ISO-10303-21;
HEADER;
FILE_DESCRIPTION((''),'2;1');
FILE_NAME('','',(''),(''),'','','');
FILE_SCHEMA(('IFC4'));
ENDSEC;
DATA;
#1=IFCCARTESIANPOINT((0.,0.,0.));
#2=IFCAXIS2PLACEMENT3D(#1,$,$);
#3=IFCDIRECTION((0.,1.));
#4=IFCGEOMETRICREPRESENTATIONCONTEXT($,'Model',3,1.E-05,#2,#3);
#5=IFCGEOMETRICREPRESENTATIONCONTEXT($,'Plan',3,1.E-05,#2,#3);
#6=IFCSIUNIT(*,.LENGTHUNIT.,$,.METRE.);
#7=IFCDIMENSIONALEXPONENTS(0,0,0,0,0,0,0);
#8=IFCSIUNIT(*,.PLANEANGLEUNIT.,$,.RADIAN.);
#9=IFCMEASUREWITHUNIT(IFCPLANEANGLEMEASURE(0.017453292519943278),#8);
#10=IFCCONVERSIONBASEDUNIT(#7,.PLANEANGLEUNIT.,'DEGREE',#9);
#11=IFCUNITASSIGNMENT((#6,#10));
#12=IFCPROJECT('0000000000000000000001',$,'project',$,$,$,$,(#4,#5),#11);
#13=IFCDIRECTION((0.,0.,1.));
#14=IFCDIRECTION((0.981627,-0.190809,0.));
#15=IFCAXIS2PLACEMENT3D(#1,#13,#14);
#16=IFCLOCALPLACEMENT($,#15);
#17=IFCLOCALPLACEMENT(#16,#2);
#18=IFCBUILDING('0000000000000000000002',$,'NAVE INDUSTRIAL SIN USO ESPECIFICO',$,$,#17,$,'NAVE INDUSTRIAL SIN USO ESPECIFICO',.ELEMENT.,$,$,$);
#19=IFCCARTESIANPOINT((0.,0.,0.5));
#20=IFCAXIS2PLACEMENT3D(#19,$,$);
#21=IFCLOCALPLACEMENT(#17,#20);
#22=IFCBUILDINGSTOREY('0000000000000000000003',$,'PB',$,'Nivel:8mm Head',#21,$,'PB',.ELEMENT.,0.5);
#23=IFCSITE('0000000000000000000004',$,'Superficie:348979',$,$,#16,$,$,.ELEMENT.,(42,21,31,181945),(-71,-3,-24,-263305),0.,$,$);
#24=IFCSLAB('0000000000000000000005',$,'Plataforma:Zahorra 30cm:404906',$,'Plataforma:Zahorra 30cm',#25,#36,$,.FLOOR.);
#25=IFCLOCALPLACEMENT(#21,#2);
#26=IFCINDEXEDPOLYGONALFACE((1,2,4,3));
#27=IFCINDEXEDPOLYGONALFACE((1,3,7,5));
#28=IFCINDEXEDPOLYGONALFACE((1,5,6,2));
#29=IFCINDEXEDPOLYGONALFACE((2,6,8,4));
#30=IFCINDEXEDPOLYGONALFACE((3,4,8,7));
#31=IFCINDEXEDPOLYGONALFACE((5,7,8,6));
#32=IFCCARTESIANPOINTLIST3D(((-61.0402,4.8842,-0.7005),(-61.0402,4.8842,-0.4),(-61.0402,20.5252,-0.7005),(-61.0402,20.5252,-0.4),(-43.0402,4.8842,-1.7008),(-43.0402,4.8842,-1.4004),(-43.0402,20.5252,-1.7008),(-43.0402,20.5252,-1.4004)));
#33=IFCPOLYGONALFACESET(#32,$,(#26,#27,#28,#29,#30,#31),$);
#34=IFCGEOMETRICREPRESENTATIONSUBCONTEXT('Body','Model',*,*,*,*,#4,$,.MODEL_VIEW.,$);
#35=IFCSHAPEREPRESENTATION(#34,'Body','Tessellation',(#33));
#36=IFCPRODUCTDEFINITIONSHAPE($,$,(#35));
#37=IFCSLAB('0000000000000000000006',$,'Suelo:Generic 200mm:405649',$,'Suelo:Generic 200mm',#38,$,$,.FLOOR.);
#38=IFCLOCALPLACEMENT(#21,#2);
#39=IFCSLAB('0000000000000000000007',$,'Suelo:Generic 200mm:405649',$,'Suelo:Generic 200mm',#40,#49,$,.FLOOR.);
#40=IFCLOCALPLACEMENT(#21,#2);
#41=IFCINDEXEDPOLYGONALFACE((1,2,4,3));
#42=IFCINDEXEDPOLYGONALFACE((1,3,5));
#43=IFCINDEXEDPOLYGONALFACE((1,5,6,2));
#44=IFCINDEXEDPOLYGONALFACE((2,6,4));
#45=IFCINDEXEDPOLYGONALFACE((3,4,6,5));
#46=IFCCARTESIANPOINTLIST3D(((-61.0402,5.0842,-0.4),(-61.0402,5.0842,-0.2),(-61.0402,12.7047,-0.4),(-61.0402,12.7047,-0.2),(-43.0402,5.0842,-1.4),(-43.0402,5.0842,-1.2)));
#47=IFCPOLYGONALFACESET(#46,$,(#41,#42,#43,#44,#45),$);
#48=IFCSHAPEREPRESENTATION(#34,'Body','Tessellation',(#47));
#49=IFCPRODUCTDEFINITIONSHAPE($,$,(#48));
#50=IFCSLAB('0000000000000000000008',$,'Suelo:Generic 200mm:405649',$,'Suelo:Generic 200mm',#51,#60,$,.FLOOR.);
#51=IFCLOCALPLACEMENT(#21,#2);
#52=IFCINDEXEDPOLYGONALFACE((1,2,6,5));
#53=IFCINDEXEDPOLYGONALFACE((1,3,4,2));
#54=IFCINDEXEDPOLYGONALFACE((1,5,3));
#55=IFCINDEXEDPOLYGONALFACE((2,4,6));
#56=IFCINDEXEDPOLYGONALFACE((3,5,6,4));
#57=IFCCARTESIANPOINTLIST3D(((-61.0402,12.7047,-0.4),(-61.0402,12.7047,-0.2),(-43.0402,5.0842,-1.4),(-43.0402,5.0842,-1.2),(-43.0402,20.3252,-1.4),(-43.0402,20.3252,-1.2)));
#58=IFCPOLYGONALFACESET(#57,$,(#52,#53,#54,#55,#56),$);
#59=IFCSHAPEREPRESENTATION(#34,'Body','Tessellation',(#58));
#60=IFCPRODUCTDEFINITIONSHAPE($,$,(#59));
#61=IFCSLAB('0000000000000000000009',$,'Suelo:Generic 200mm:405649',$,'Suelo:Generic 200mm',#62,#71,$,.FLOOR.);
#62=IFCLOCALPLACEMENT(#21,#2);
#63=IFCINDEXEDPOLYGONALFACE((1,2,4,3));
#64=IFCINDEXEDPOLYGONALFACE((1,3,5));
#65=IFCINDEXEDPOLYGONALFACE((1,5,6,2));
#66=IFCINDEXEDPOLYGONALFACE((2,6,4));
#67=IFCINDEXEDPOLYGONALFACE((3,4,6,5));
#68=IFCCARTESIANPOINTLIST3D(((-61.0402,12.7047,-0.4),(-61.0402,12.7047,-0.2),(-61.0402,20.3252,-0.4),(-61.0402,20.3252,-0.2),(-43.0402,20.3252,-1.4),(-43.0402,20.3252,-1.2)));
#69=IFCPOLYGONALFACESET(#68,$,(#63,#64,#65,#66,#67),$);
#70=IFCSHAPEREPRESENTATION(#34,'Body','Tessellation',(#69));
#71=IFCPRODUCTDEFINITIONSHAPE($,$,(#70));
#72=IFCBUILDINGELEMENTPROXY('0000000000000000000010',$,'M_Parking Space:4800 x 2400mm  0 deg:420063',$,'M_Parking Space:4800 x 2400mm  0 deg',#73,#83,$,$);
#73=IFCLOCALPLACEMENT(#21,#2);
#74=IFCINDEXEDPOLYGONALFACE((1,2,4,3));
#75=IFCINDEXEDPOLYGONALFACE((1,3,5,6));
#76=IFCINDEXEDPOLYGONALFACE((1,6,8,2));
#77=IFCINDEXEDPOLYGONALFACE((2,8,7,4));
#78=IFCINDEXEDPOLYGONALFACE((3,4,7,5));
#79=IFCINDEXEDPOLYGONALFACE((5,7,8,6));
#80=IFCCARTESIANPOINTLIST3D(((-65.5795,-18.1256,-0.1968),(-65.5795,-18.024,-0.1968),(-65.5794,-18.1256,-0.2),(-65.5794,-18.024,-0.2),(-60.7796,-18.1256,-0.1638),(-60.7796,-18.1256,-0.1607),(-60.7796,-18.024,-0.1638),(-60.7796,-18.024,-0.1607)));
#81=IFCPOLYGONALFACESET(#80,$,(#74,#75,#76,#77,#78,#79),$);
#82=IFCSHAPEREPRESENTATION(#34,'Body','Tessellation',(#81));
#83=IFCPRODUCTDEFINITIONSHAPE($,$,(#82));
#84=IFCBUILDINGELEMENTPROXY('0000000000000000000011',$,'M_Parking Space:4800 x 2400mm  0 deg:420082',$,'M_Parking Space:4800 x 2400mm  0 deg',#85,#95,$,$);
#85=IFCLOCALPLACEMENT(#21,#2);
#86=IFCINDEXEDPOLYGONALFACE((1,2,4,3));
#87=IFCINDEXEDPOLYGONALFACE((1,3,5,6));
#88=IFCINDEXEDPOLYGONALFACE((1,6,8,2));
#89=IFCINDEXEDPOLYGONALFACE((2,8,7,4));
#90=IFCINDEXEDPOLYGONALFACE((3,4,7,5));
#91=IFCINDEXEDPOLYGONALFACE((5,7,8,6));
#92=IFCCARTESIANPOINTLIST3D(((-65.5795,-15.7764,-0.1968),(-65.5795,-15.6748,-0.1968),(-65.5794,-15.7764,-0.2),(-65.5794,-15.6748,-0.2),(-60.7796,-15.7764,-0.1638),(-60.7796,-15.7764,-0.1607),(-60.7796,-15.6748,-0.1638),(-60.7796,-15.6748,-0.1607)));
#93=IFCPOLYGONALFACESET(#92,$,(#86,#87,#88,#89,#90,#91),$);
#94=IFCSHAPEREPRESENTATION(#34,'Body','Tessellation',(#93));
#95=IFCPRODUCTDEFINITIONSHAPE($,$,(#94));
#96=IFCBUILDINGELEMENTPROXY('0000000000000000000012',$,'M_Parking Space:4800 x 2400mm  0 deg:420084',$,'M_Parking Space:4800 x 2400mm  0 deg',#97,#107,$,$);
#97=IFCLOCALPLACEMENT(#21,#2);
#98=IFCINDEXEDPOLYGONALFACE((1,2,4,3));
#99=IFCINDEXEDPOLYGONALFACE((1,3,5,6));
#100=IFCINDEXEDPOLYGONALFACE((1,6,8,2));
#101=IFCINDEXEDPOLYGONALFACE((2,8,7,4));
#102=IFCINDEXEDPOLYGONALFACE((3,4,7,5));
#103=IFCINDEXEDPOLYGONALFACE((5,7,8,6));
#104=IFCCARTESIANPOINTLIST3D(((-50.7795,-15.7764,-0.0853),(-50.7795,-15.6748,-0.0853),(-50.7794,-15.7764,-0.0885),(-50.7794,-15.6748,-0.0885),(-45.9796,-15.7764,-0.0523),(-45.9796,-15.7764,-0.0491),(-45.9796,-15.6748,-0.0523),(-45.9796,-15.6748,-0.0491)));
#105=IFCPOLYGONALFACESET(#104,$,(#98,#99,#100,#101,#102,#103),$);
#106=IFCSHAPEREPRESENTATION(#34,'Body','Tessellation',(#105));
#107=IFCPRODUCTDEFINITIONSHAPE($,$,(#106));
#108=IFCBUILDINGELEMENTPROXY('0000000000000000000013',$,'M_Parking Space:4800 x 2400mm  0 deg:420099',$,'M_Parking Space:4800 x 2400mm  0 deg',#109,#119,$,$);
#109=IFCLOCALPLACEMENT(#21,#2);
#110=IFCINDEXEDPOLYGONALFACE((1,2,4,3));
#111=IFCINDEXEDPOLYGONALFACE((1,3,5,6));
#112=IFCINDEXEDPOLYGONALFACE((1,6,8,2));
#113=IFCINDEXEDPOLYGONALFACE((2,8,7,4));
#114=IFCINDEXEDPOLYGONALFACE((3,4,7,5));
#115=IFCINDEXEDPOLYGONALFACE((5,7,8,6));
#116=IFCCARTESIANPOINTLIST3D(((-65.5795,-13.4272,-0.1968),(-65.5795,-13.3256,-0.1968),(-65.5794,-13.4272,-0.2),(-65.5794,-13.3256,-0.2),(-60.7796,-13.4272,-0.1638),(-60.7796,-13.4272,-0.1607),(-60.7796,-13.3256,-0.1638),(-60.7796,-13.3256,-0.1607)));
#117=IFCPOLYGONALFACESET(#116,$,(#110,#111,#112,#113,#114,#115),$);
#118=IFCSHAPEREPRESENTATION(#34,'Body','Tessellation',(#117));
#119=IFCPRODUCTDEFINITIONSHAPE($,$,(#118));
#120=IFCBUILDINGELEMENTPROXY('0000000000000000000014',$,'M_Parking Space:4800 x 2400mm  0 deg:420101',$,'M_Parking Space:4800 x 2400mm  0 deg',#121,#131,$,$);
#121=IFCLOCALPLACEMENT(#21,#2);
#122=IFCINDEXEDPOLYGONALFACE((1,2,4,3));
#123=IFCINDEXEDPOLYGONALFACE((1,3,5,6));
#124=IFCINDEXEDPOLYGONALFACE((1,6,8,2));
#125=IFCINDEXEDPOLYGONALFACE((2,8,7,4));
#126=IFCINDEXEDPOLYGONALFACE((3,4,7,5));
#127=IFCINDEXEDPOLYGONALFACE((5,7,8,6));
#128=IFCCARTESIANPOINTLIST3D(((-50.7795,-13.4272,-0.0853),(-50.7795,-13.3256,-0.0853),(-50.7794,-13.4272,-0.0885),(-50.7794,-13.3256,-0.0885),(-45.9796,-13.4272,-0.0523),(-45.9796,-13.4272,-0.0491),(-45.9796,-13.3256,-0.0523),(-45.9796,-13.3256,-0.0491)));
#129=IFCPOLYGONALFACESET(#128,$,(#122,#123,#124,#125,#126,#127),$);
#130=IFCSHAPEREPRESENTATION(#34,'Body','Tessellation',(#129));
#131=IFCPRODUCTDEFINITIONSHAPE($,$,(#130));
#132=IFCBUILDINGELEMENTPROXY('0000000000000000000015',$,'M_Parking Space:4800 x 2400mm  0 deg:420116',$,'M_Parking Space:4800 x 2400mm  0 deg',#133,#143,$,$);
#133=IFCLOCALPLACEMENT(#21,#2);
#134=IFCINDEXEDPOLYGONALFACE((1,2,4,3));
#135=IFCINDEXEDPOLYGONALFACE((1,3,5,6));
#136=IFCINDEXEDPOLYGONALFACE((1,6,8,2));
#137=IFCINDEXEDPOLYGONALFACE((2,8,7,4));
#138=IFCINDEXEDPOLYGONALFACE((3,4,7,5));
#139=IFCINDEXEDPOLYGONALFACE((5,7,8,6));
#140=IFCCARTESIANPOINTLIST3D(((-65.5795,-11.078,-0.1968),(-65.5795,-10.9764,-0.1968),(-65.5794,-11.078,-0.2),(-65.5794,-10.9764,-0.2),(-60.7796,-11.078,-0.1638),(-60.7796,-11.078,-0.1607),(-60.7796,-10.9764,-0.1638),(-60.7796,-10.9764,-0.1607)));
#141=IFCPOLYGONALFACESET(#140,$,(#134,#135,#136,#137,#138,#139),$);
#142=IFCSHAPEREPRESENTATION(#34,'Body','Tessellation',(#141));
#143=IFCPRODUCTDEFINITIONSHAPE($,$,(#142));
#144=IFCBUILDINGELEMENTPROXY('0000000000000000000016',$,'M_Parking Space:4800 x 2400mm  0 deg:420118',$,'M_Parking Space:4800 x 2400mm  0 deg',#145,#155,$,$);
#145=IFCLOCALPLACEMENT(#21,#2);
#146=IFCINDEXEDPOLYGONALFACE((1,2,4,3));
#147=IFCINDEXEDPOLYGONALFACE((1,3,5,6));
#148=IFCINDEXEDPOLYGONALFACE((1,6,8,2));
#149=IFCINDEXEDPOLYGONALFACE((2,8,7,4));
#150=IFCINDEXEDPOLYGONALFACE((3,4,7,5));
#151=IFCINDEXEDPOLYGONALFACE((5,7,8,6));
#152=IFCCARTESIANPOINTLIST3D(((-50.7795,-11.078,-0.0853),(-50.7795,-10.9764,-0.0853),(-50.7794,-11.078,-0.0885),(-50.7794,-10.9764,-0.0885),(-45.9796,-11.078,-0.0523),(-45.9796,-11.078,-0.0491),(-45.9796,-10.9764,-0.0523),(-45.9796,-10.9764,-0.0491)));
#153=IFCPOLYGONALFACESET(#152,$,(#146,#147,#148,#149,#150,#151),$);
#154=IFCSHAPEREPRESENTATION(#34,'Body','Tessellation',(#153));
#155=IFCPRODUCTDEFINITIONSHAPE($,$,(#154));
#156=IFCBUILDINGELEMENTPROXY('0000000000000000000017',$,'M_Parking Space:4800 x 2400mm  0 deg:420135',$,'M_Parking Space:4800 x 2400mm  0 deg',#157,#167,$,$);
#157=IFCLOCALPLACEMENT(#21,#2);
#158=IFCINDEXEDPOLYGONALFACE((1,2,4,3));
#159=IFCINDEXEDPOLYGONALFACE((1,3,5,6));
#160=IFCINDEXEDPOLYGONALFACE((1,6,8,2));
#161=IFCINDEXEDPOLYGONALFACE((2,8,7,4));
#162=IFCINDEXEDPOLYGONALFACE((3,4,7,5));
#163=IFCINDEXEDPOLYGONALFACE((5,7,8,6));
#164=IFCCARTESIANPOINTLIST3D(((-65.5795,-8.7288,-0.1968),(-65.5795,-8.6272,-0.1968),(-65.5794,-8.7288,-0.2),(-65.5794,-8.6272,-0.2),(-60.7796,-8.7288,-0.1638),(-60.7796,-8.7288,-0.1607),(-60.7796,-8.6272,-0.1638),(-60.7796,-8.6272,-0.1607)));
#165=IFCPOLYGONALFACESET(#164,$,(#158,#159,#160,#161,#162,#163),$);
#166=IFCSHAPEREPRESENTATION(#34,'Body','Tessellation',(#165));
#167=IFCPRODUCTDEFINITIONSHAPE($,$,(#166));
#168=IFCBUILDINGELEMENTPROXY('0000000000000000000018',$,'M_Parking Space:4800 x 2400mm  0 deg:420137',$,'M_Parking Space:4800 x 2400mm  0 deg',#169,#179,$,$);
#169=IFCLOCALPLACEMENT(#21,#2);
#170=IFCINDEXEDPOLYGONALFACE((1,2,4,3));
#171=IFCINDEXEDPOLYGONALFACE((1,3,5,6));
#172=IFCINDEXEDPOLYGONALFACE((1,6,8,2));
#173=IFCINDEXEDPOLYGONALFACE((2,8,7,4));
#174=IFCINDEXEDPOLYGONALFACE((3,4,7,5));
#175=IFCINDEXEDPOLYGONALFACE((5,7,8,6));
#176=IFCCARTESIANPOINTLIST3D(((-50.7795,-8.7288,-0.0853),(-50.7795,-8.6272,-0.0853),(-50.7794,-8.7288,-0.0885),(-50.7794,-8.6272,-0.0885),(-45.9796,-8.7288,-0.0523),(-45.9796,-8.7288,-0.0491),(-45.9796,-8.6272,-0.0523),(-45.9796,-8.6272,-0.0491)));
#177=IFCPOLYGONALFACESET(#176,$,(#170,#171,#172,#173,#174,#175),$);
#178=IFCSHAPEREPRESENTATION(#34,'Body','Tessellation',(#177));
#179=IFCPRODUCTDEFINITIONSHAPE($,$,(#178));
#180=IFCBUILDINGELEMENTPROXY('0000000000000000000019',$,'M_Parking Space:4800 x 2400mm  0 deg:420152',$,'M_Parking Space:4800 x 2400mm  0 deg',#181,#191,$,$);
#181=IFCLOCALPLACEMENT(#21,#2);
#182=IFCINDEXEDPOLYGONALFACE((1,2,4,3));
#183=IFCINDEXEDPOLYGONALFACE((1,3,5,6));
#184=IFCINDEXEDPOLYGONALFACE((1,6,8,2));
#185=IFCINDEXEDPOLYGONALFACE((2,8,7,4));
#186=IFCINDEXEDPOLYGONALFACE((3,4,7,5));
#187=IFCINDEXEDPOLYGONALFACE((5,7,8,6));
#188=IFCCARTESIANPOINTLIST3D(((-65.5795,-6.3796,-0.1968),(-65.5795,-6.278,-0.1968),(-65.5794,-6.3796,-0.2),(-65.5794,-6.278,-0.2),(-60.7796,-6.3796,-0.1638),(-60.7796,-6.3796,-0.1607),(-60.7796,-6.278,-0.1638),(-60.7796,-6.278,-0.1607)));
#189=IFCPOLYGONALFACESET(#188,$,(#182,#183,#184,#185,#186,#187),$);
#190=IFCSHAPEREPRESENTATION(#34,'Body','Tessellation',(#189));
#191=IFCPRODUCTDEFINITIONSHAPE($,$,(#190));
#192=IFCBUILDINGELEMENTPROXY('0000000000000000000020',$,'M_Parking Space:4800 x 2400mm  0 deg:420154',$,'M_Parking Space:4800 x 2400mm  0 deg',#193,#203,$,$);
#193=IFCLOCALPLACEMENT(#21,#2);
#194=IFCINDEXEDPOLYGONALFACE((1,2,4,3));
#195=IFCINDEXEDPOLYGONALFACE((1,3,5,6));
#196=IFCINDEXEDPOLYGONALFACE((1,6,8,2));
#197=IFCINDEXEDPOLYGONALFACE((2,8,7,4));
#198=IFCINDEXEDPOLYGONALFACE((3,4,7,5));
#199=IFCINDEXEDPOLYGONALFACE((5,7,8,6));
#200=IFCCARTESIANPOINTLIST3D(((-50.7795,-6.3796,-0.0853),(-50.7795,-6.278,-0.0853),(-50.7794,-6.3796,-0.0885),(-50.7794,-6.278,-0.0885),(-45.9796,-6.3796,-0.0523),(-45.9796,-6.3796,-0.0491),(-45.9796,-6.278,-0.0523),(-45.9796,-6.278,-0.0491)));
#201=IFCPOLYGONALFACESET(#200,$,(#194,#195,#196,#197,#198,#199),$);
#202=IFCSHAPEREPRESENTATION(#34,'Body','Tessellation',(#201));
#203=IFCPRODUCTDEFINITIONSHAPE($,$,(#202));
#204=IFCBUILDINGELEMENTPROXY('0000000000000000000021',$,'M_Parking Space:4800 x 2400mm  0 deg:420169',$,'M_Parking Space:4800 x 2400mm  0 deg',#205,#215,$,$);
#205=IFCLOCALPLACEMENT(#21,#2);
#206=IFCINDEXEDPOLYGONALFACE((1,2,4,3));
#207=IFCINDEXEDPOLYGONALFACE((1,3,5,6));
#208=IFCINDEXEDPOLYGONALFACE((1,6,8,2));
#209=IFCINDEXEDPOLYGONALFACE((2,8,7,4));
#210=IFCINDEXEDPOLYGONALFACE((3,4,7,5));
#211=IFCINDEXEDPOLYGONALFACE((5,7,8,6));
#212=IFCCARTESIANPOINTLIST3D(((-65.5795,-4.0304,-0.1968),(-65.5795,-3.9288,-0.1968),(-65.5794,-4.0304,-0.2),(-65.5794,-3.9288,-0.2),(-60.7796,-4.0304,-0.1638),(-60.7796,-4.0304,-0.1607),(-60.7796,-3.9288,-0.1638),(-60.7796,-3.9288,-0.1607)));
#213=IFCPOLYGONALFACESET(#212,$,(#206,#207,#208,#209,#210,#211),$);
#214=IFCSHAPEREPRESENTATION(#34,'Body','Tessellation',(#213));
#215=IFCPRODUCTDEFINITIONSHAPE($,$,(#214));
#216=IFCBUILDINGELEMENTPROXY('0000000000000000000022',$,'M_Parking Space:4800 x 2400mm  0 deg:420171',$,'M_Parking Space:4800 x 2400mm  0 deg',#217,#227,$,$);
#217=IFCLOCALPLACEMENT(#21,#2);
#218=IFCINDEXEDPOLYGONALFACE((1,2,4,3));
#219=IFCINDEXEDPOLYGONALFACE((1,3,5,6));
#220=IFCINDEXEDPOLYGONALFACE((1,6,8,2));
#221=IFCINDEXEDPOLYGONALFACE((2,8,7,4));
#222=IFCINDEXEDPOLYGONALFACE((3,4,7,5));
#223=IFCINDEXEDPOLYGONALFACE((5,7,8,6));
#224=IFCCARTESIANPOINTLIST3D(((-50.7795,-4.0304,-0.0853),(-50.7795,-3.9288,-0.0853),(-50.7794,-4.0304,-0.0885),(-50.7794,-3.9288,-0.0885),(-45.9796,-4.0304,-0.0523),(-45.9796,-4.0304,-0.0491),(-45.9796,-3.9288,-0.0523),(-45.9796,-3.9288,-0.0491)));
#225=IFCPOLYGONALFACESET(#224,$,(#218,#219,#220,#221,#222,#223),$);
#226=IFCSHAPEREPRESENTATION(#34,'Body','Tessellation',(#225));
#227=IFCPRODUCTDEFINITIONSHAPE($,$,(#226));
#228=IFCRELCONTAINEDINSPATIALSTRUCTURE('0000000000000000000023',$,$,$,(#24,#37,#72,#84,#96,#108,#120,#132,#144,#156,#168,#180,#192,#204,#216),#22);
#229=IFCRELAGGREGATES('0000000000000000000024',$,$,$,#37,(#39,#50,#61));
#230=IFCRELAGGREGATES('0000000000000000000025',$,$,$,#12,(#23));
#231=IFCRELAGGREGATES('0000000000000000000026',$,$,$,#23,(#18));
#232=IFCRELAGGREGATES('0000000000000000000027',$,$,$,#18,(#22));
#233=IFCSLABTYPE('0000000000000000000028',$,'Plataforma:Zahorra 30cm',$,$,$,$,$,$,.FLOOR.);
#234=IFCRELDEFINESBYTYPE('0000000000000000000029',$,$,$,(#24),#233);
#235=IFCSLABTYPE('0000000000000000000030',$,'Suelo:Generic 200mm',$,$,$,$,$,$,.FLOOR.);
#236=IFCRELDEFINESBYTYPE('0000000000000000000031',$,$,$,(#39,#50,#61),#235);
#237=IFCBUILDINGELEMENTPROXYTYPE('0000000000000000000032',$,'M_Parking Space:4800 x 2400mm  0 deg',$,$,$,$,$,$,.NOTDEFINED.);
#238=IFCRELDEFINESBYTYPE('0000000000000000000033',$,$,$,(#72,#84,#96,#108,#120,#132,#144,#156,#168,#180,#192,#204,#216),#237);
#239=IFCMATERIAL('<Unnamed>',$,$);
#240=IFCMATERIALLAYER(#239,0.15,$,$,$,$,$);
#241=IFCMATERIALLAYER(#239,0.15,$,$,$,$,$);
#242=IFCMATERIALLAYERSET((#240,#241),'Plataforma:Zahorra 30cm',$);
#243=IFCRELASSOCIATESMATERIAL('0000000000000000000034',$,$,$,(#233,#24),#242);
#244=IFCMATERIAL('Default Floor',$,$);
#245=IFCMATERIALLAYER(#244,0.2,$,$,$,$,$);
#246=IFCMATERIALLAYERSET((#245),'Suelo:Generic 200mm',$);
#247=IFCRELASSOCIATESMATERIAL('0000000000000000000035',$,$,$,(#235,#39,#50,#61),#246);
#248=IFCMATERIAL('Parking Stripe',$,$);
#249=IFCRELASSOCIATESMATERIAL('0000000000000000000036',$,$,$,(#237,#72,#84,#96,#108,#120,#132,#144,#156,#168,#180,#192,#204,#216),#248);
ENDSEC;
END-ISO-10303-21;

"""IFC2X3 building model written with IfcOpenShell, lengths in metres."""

from ifc_helpers import new_model, entity, si_unit, converted_unit, direction, frame, frame_2d, origin, origin_2d_with_axis, place, context, subcontext, project, spatial, polyline, rectangle, outline, extrude, source, transform, mapped, material, layer, layer_set, layer_usage, type_object, type_shapes, element, aggregate, save


model = new_model("IFC2X3")

# Units and contexts
model_context = context("Model", 3, precision=1e-05, world=origin(), true_north=direction((0.0, 1.0)))
plan_context = context("Plan", 3, precision=1e-05, world=origin(), true_north=direction((0.0, 1.0)))
body_context = subcontext(model_context, "Body", "Model", "MODEL_VIEW")
ifc_project = project(units=[si_unit("LENGTHUNIT", "METRE"), converted_unit("PLANEANGLEUNIT", "DEGREE", entity("IfcPlaneAngleMeasure", 0.017453292519943278), si_unit("PLANEANGLEUNIT", "RADIAN"), dimensions=[0, 0, 0, 0, 0, 0, 0])], contexts=[model_context, plan_context])

# Site, building, storey
site_placement = place(None, frame((0.0, 0.0, 0.0), z_axis=(0.0, 0.0, 1.0), x_axis=(0.981627, -0.190809, 0.0)))
site = spatial("IfcSite", under=ifc_project, at=site_placement, Name="Superficie:348979", CompositionType="ELEMENT", RefLatitude=(42, 21, 31, 181945), RefLongitude=(-71, -3, -24, -263305), RefElevation=0.0)
building_placement = place(site_placement, origin())
building = spatial("IfcBuilding", under=site, at=building_placement, Name="NAVE INDUSTRIAL SIN USO ESPECIFICO", LongName="NAVE INDUSTRIAL SIN USO ESPECIFICO", CompositionType="ELEMENT")
storey_placement = place(building_placement, frame((0.0, 0.0, 0.5)))
storey = spatial("IfcBuildingStorey", under=building, at=storey_placement, Name="PB", ObjectType="Nivel:8mm Head", LongName="PB", CompositionType="ELEMENT", Elevation=0.5)

# Slab
ifc_material_1 = material(Name="<Unnamed>")
ifc_layer_1 = layer(ifc_material_1, 0.15)
ifc_layer_2 = layer(ifc_material_1, 0.15)
ifc_layer_set_1 = layer_set([ifc_layer_1, ifc_layer_2], Name="Plataforma:Zahorra 30cm")
ifc_layer_usage = layer_usage(ifc_layer_set_1, "AXIS3", "NEGATIVE", 0.0)
slab_type_1 = type_object("IfcSlabType", Name="Plataforma:Zahorra 30cm", PredefinedType="FLOOR", material=ifc_layer_set_1)
slab_1_placement = place(storey_placement, frame((-61.0402, 4.8842, -1.7008)))
element("IfcSlab", 1, at=slab_1_placement, inside=storey, type_object=slab_type_1, material=ifc_layer_usage, Name="Plataforma:Zahorra 30cm:404906", ObjectType="Plataforma:Zahorra 30cm", PredefinedType="FLOOR", context=body_context, shape_type="SweptSolid", body=[
    extrude(rectangle(XDim=18.0278, YDim=15.641, at=frame_2d((-9.0139, -0.4295), x_axis=(1.0, 0.0))), frame((18.0, 7.391, 0.3005), z_axis=(-0.05549, 0.0, -0.998459), x_axis=(0.998459, 0.0, -0.05549)), (0.05549, 0.0, 0.998459), 0.3005),
])

# Slabs
slab_2_placement = place(storey_placement, frame((-61.0402, 5.0842, -1.4)))
slab_2 = element("IfcSlab", 2, at=slab_2_placement, inside=storey, Name="Suelo:Generic 200mm:405649", ObjectType="Suelo:Generic 200mm", PredefinedType="FLOOR")
ifc_material_2 = material(Name="Default Floor")
ifc_layer_3 = layer(ifc_material_2, 0.2)
ifc_layer_set_2 = layer_set([ifc_layer_3], Name="Suelo:Generic 200mm")
slab_type_2 = type_object("IfcSlabType", Name="Suelo:Generic 200mm", PredefinedType="FLOOR", material=ifc_layer_set_2)
slab_3_placement = place(slab_2_placement, origin())
slab_3 = element("IfcSlab", 3, at=slab_3_placement, type_object=slab_type_2, material=ifc_layer_set_2, Name="Suelo:Generic 200mm:405649", ObjectType="Suelo:Generic 200mm", PredefinedType="FLOOR", context=body_context, shape_type="SweptSolid", body=[
    extrude(outline(polyline([(-9.0139, -3.8102), (9.0139, -3.8102), (-9.0139, 3.8102), (-9.0139, -3.8102)])), frame((9.0, 3.8102, 0.7), z_axis=(0.05547, 0.0, 0.99846), x_axis=(0.99846, 0.0, -0.05547)), (0.05547, 0.0, -0.99846), 0.2),
])
slab_4_placement = place(slab_2_placement, origin())
slab_4 = element("IfcSlab", 4, at=slab_4_placement, type_object=slab_type_2, material=ifc_layer_set_2, Name="Suelo:Generic 200mm:405649", ObjectType="Suelo:Generic 200mm", PredefinedType="FLOOR", context=body_context, shape_type="SweptSolid", body=[
    extrude(outline(polyline([(9.0139, -7.6205), (9.0139, 7.6205), (-9.0139, 0.0), (9.0139, -7.6205)])), frame((9.0, 7.6205, 0.7), z_axis=(0.05547, 0.0, 0.99846), x_axis=(0.99846, 0.0, -0.05547)), (0.05547, 0.0, -0.99846), 0.2),
])
slab_5_placement = place(slab_2_placement, origin())
slab_5 = element("IfcSlab", 5, at=slab_5_placement, type_object=slab_type_2, material=ifc_layer_set_2, Name="Suelo:Generic 200mm:405649", ObjectType="Suelo:Generic 200mm", PredefinedType="FLOOR", context=body_context, shape_type="SweptSolid", body=[
    extrude(outline(polyline([(9.0139, 3.8102), (-9.0139, 3.8102), (-9.0139, -3.8102), (9.0139, 3.8102)])), frame((9.0, 11.4307, 0.7), z_axis=(0.05547, 0.0, 0.99846), x_axis=(0.99846, 0.0, -0.05547)), (0.05547, 0.0, -0.99846), 0.2),
])
aggregate(slab_2, [slab_3, slab_4, slab_5])

# Building element proxies
ifc_material_3 = material(Name="Parking Stripe")
building_element_proxy_type_1 = type_object("IfcBuildingElementProxyType", Name="M_Parking Space:4800 x 2400mm  0 deg", PredefinedType="NOTDEFINED", material=ifc_material_3)
shared_shape_1 = source(origin(), body_context, "Body", "SweptSolid", [
    extrude(rectangle(XDim=4.8, YDim=0.1016, at=origin_2d_with_axis()), frame((0.0, -2.4, 0.0), z_axis=(0.0, 0.0, 1.0), x_axis=(0.0, -1.0, 0.0)), (0.0, 0.0, 1.0), 0.0032),
])
type_shapes(building_element_proxy_type_1, [shared_shape_1])
for number, where, z_axis, x_axis, name in (
    (6, (-65.5794, -18.0748, -0.2), (-0.007536, 0.0, 0.999972), (0.0, 1.0, 0.0), "M_Parking Space:4800 x 2400mm  0 deg:420063"),
    (7, (-65.5794, -15.7256, -0.2), (-0.007536, 0.0, 0.999972), (0.0, 1.0, 0.0), "M_Parking Space:4800 x 2400mm  0 deg:420082"),
    (8, (-50.7794, -15.7256, -0.0885), (-0.007536, 0.0, 0.999972), (0.0, 1.0, 0.0), "M_Parking Space:4800 x 2400mm  0 deg:420084"),
    (9, (-65.5794, -13.3764, -0.2), (-0.007536, 0.0, 0.999972), (0.0, 1.0, 0.0), "M_Parking Space:4800 x 2400mm  0 deg:420099"),
    (10, (-50.7794, -13.3764, -0.0885), (-0.007536, 0.0, 0.999972), (0.0, 1.0, 0.0), "M_Parking Space:4800 x 2400mm  0 deg:420101"),
    (11, (-65.5794, -11.0272, -0.2), (-0.007536, 0.0, 0.999972), (0.0, 1.0, 0.0), "M_Parking Space:4800 x 2400mm  0 deg:420116"),
    (12, (-50.7794, -11.0272, -0.0885), (-0.007536, 0.0, 0.999972), (0.0, 1.0, 0.0), "M_Parking Space:4800 x 2400mm  0 deg:420118"),
    (13, (-65.5794, -8.678, -0.2), (-0.007536, 0.0, 0.999972), (0.0, 1.0, 0.0), "M_Parking Space:4800 x 2400mm  0 deg:420135"),
    (14, (-50.7794, -8.678, -0.0885), (-0.007536, 0.0, 0.999972), (0.0, 1.0, 0.0), "M_Parking Space:4800 x 2400mm  0 deg:420137"),
    (15, (-65.5794, -6.3288, -0.2), (-0.007536, 0.0, 0.999972), (0.0, 1.0, 0.0), "M_Parking Space:4800 x 2400mm  0 deg:420152"),
    (16, (-50.7794, -6.3288, -0.0885), (-0.007536, 0.0, 0.999972), (0.0, 1.0, 0.0), "M_Parking Space:4800 x 2400mm  0 deg:420154"),
    (17, (-65.5794, -3.9796, -0.2), (-0.007536, 0.0, 0.999972), (0.0, 1.0, 0.0), "M_Parking Space:4800 x 2400mm  0 deg:420169"),
    (18, (-50.7794, -3.9796, -0.0885), (-0.007536, 0.0, 0.999972), (0.0, 1.0, 0.0), "M_Parking Space:4800 x 2400mm  0 deg:420171"),
):
    element("IfcBuildingElementProxy", number, at=place(storey_placement, frame(where, z_axis=z_axis, x_axis=x_axis)), inside=storey, type_object=building_element_proxy_type_1, material=ifc_material_3, Name=name, ObjectType="M_Parking Space:4800 x 2400mm  0 deg", context=body_context, shape_type="MappedRepresentation", body=[
        mapped(shared_shape_1, transform((0.0, 0.0, 0.0), scale=1.0)),
    ])

save(model, "model.ifc")
